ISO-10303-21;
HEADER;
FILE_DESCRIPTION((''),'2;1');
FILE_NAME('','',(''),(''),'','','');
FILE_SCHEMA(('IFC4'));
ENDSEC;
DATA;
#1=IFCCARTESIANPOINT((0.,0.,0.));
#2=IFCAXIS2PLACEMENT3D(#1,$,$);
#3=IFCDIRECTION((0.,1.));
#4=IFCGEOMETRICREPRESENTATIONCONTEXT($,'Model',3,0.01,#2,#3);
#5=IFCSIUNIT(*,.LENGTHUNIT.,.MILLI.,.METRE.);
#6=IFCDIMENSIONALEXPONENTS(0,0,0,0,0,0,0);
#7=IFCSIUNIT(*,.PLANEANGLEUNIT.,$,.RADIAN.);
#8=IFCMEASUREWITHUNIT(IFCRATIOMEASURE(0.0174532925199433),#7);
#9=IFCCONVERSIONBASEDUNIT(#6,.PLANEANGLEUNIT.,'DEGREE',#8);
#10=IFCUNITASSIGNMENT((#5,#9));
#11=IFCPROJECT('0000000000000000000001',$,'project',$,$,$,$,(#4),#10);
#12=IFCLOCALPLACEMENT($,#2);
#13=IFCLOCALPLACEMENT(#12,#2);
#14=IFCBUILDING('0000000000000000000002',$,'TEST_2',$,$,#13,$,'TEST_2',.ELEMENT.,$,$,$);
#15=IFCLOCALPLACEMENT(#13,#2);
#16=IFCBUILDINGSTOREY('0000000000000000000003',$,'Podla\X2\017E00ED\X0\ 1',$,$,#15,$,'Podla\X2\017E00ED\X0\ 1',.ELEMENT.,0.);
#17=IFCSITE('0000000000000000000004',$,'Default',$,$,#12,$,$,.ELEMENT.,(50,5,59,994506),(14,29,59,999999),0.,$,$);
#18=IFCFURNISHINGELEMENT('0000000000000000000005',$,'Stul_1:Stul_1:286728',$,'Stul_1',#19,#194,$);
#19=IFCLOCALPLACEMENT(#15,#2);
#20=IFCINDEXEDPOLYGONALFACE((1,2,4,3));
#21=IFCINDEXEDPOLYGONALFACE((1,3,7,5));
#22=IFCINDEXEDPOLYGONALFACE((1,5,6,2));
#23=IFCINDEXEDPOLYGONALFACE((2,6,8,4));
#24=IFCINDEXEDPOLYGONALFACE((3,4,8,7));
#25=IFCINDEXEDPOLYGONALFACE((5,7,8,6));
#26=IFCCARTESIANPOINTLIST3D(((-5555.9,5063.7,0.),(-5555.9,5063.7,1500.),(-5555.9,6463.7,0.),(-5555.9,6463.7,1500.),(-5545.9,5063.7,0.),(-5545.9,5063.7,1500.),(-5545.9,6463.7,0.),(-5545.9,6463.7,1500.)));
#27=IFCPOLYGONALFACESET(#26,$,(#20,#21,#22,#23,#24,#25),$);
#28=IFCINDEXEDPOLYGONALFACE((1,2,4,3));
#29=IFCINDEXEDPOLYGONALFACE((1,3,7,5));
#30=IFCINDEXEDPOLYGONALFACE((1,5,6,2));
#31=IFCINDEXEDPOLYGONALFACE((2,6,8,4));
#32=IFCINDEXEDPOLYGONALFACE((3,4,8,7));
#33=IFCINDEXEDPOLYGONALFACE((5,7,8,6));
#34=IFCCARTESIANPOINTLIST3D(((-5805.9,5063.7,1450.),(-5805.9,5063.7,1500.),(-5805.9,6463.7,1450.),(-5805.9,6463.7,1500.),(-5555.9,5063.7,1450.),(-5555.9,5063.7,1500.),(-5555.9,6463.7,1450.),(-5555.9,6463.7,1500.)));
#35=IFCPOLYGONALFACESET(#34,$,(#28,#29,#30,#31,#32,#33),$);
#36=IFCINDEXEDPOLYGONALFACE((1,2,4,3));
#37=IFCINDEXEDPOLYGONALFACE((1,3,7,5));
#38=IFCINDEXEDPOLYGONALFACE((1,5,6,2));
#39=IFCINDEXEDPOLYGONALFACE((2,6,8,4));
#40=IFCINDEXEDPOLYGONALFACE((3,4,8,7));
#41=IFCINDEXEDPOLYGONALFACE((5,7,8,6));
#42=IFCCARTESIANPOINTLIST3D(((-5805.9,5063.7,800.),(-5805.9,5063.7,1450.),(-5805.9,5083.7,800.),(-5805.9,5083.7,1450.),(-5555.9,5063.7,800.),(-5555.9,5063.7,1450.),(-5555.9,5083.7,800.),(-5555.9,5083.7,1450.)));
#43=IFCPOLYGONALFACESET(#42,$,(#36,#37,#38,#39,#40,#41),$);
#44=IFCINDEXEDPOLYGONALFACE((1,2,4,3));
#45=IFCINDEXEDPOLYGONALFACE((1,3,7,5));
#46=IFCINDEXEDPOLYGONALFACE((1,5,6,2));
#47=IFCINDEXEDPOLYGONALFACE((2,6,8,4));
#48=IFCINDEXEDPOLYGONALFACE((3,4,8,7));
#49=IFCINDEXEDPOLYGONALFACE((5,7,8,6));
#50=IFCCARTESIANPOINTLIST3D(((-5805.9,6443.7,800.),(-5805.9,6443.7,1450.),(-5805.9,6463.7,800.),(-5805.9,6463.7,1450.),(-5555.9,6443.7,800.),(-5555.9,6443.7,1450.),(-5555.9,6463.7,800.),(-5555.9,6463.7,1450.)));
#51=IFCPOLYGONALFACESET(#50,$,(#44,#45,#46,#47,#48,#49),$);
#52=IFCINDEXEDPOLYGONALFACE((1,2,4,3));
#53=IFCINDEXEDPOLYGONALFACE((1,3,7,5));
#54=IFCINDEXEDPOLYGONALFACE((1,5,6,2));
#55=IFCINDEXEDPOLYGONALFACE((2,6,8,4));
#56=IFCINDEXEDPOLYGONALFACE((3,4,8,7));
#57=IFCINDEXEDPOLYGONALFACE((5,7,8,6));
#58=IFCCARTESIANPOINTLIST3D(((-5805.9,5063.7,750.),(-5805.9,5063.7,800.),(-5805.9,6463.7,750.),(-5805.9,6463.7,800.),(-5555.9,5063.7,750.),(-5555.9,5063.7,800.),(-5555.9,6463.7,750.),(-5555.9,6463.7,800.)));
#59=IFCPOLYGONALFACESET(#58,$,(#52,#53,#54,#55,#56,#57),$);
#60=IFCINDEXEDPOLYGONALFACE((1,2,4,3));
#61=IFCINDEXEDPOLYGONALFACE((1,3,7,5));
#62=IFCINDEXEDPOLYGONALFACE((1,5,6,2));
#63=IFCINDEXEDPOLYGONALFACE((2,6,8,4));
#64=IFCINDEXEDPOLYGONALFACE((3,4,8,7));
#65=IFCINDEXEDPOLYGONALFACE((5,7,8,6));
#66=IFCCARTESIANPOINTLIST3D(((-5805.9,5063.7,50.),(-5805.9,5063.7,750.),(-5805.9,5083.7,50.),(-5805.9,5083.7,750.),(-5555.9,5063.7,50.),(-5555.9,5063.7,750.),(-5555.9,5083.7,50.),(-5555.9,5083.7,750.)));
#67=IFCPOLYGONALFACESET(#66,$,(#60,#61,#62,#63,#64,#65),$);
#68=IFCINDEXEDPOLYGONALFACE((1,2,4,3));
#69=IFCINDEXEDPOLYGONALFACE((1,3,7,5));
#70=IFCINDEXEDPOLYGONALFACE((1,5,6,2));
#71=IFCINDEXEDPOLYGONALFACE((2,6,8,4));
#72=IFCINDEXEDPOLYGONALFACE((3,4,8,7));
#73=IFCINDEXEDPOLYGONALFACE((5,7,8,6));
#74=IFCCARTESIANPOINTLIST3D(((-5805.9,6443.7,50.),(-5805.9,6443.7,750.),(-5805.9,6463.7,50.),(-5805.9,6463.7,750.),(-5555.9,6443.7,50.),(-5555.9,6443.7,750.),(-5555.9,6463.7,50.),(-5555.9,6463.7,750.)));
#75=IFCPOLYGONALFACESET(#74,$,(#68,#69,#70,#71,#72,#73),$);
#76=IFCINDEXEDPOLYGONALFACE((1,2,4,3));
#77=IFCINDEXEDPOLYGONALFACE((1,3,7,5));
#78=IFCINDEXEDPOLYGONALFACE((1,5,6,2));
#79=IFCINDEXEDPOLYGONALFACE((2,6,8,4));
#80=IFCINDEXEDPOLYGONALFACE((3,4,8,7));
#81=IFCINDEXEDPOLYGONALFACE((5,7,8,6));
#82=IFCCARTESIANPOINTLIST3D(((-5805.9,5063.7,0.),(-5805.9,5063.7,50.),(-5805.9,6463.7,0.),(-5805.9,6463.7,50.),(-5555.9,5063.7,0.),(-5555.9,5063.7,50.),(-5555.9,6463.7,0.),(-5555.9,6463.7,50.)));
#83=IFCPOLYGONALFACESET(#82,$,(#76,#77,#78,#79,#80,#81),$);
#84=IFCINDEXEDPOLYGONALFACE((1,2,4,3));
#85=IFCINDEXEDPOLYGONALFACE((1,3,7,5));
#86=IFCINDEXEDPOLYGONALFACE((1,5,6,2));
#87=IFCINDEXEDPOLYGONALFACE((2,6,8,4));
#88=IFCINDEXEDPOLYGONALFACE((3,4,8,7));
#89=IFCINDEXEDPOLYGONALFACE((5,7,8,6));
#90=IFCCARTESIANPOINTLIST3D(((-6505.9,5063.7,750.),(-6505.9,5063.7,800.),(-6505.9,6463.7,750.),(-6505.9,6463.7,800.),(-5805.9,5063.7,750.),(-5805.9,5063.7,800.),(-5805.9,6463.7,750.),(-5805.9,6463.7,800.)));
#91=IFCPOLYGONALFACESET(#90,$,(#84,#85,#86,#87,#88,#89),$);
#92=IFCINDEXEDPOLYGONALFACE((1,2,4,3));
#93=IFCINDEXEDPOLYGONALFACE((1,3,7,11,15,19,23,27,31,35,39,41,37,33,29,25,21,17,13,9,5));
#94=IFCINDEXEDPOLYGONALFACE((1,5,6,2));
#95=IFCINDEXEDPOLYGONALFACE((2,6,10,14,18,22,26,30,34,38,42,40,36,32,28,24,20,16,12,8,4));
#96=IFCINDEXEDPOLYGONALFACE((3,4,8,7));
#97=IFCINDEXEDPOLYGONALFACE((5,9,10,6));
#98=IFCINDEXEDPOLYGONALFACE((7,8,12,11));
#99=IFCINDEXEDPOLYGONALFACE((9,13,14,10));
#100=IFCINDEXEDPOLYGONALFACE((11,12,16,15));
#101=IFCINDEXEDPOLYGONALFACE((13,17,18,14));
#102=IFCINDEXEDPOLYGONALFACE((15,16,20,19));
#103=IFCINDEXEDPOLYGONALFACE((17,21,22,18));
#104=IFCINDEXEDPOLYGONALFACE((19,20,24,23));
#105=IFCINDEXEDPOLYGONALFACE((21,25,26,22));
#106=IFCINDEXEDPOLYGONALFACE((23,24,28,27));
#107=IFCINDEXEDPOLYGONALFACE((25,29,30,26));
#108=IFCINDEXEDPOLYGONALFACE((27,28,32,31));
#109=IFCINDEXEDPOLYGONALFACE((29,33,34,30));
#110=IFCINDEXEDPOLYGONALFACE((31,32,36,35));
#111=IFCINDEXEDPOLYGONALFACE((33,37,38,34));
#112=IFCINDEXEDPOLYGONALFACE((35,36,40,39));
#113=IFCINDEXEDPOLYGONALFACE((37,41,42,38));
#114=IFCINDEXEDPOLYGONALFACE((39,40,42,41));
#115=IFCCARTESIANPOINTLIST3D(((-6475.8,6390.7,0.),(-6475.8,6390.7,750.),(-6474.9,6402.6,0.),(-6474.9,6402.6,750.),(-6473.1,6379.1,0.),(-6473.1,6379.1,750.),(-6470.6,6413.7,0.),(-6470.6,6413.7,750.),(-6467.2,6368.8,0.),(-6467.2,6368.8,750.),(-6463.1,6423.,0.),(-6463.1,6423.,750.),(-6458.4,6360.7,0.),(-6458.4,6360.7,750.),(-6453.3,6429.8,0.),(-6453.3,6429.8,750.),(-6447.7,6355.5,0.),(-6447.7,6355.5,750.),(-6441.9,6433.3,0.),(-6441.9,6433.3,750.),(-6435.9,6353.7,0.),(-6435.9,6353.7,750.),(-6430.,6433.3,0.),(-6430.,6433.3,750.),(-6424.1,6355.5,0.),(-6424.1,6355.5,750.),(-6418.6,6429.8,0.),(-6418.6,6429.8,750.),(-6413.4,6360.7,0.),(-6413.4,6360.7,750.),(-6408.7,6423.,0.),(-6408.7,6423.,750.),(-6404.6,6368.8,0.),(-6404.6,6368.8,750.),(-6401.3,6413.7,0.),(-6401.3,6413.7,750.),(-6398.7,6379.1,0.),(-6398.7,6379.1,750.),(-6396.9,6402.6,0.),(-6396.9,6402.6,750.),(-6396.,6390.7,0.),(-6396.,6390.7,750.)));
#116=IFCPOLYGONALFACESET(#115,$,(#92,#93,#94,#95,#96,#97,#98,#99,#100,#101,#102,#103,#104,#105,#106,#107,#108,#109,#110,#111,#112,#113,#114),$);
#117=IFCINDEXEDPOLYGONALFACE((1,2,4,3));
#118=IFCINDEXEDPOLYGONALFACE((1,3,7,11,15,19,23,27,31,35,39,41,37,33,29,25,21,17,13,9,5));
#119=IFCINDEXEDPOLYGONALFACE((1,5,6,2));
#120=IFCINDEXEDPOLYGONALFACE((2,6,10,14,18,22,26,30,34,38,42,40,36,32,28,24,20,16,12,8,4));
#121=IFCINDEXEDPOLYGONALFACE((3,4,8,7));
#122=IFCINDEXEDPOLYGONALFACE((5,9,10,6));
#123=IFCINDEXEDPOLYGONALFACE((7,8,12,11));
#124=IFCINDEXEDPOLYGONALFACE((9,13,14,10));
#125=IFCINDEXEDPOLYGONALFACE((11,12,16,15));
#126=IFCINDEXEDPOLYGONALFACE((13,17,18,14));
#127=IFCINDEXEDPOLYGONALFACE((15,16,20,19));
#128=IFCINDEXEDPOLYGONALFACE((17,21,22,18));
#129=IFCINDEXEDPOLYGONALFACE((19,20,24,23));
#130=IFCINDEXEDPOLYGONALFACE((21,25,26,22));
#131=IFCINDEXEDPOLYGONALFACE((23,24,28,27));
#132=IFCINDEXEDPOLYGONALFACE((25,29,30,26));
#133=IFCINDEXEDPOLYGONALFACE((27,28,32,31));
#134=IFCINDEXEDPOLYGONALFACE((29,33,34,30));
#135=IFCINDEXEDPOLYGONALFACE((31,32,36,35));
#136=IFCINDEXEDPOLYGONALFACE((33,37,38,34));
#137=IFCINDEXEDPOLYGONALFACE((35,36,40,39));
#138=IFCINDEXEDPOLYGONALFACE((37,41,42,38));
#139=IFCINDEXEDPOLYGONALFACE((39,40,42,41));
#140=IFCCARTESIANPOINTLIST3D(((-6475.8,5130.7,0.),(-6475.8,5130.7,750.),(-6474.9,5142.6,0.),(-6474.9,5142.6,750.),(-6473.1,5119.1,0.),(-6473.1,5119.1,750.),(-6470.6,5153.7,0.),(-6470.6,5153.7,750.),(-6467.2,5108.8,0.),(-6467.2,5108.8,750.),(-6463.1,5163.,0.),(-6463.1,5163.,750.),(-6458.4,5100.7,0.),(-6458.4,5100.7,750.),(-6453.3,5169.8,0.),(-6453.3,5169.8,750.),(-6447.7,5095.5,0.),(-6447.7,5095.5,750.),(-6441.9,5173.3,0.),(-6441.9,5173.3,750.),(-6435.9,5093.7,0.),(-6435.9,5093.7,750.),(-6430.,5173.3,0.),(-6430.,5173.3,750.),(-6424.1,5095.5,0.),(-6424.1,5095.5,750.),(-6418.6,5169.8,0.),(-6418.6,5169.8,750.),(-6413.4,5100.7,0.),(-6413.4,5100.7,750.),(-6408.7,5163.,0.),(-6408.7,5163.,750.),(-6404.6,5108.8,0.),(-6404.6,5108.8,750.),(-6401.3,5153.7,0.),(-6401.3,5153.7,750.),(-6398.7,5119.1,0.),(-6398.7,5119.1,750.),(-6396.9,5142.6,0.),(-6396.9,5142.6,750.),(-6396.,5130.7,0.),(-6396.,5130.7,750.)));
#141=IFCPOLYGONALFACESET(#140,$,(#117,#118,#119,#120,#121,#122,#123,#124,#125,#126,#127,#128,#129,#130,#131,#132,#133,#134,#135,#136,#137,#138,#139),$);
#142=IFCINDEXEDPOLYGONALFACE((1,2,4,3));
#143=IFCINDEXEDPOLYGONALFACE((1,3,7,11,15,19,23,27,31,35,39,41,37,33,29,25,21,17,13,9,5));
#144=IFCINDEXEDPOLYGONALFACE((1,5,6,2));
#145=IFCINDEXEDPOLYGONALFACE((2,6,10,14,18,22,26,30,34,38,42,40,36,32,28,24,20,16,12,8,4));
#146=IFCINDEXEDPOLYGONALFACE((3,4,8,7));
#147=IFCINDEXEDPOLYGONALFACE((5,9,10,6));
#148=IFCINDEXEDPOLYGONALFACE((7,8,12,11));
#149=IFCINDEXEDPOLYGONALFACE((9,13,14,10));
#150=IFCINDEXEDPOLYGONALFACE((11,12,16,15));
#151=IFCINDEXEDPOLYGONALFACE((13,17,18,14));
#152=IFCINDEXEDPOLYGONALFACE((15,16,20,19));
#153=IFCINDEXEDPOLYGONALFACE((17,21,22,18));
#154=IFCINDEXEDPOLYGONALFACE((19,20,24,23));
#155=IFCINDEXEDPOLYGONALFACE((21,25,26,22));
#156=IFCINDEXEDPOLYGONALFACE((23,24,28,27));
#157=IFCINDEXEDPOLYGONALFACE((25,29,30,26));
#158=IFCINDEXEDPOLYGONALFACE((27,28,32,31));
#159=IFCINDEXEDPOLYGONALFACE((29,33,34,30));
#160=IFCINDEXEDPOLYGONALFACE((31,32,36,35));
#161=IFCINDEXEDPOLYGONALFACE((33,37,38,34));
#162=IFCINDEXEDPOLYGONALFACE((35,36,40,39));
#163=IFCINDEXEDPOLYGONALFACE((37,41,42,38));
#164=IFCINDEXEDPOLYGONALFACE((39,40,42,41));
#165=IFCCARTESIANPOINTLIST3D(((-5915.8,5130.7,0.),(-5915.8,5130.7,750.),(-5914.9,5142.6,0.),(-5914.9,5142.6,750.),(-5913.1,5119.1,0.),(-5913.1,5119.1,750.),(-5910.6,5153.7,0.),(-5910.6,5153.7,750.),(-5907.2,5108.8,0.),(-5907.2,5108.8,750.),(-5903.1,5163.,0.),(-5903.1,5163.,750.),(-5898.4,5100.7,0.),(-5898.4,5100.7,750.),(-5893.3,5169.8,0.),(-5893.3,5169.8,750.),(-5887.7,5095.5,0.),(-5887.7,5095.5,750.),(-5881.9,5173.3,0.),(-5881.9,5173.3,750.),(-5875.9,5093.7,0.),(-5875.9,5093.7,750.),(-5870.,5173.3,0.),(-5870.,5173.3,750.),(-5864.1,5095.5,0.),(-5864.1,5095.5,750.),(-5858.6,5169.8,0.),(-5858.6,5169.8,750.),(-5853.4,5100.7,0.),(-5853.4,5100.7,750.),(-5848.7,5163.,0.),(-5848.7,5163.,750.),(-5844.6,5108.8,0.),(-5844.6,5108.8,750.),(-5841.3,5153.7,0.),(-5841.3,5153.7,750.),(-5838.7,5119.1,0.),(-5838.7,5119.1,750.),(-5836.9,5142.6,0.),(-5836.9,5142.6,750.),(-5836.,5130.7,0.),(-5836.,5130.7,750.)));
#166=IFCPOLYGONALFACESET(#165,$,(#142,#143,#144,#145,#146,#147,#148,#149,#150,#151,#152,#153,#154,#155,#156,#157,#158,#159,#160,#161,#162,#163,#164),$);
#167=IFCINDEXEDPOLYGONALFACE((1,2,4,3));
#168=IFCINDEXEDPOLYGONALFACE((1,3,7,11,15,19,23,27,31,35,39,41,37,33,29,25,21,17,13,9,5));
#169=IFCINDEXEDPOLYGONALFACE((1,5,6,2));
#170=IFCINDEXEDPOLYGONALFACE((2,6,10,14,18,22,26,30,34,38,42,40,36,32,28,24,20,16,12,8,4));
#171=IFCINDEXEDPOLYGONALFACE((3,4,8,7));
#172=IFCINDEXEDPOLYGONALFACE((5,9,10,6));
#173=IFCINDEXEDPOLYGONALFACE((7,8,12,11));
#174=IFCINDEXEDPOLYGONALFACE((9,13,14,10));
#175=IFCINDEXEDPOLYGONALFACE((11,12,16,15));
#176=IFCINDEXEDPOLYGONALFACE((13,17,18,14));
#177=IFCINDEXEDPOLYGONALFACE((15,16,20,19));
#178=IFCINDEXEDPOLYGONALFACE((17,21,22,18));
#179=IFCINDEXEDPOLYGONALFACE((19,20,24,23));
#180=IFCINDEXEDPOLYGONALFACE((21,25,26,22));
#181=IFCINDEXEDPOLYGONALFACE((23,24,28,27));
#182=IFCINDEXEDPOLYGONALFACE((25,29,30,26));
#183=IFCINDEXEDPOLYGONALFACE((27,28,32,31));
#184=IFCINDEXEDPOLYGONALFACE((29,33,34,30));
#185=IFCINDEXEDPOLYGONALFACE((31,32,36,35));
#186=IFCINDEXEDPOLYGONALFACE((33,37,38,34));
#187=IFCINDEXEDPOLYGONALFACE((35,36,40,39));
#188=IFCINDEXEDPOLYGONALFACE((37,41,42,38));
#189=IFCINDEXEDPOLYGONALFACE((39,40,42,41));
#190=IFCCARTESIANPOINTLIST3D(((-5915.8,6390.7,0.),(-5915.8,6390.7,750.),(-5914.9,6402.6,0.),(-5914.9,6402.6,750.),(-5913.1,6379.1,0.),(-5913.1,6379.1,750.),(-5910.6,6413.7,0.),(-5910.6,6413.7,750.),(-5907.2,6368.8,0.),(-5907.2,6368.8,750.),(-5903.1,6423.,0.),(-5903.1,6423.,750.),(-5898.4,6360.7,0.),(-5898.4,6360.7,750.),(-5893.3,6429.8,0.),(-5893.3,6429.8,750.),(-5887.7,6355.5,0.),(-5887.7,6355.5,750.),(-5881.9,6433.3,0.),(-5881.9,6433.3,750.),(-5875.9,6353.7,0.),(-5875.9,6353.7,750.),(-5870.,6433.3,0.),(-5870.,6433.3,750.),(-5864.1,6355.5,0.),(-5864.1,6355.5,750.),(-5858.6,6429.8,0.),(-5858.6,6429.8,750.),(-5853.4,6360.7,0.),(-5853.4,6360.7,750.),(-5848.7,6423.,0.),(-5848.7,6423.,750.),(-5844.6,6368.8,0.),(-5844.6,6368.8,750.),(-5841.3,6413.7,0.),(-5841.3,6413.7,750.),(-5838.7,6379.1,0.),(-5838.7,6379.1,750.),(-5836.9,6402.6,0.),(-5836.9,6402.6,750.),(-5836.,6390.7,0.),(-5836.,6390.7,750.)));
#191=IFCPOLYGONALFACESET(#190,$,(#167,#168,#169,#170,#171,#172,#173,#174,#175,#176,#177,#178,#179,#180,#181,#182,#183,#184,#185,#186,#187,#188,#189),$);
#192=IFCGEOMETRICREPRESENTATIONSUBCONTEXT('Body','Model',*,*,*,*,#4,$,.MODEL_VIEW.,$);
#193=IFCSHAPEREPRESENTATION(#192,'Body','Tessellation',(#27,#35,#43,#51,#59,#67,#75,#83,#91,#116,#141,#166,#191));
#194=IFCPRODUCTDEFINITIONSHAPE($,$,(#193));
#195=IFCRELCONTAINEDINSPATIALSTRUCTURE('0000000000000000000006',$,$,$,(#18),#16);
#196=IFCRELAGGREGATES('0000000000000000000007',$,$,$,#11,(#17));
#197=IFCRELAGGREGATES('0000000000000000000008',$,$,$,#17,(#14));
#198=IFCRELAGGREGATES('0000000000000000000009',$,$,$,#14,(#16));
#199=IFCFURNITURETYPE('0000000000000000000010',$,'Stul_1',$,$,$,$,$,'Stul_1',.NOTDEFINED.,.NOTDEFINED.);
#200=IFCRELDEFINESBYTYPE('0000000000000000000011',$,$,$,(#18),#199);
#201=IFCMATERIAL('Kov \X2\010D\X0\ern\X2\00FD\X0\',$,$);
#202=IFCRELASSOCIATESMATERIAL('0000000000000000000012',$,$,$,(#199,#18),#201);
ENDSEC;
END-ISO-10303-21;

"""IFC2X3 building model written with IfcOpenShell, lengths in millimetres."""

from ifc_helpers import new_model, entity, si_unit, converted_unit, direction, frame, frame_2d, origin, origin_2d_with_axis, place, context, subcontext, project, spatial, rectangle, circle, extrude, source, transform, mapped, material, type_object, type_shapes, element, save


model = new_model("IFC2X3")

# Units and contexts
model_context = context("Model", 3, precision=0.01, world=origin(), true_north=direction((0.0, 1.0)))
body_context = subcontext(model_context, "Body", "Model", "MODEL_VIEW")
ifc_project = project(units=[si_unit("LENGTHUNIT", "METRE", prefix="MILLI"), converted_unit("PLANEANGLEUNIT", "DEGREE", entity("IfcRatioMeasure", 0.0174532925199433), si_unit("PLANEANGLEUNIT", "RADIAN"), dimensions=[0, 0, 0, 0, 0, 0, 0])], contexts=[model_context])

# Site, building, storey
site_placement = place(None, origin())
site = spatial("IfcSite", under=ifc_project, at=site_placement, Name="Default", CompositionType="ELEMENT", RefLatitude=(50, 5, 59, 994506), RefLongitude=(14, 29, 59, 999999), RefElevation=0.0)
building_placement = place(site_placement, origin())
building = spatial("IfcBuilding", under=site, at=building_placement, Name="TEST_2", LongName="TEST_2", CompositionType="ELEMENT")
storey_placement = place(building_placement, origin())
storey = spatial("IfcBuildingStorey", under=building, at=storey_placement, Name="Podlaží 1", LongName="Podlaží 1", CompositionType="ELEMENT", Elevation=0.0)

# Furnishing element
ifc_material_1 = material(Name="Kov černý")
furniture_type = type_object("IfcFurnitureType", Name="Stul_1", ElementType="Stul_1", material=ifc_material_1)
shared_shape_1 = source(origin(), body_context, "Body", "SweptSolid", [
    extrude(rectangle(XDim=1400.0, YDim=10.0, at=origin_2d_with_axis()), frame((0.0, 605.0, 0.0), z_axis=(0.0, 0.0, 1.0), x_axis=(-1.0, 0.0, 0.0)), (0.0, 0.0, 1.0), 1500.0),
    extrude(rectangle(XDim=1400.0, YDim=250.0, at=frame_2d((0.0, 0.0), x_axis=(1.0, 0.0))), frame((0.0, 475.0, 1450.0), z_axis=(0.0, 0.0, 1.0), x_axis=(-1.0, 0.0, 0.0)), (0.0, 0.0, 1.0), 50.0),
    extrude(rectangle(XDim=20.0, YDim=250.0, at=origin_2d_with_axis()), frame((690.0, 475.0, 800.0), z_axis=(0.0, 0.0, 1.0), x_axis=(-1.0, 0.0, 0.0)), (0.0, 0.0, 1.0), 650.0),
    extrude(rectangle(XDim=20.0, YDim=250.0, at=frame_2d((0.0, 0.0), x_axis=(1.0, 0.0))), frame((-690.0, 475.0, 800.0), z_axis=(0.0, 0.0, 1.0), x_axis=(-1.0, 0.0, 0.0)), (0.0, 0.0, 1.0), 650.0),
    extrude(rectangle(XDim=1400.0, YDim=250.0, at=origin_2d_with_axis()), frame((0.0, 475.0, 750.0), z_axis=(0.0, 0.0, 1.0), x_axis=(-1.0, 0.0, 0.0)), (0.0, 0.0, 1.0), 50.0),
    extrude(rectangle(XDim=20.0, YDim=250.0, at=origin_2d_with_axis()), frame((690.0, 475.0, 50.0), z_axis=(0.0, 0.0, 1.0), x_axis=(-1.0, 0.0, 0.0)), (0.0, 0.0, 1.0), 700.0),
    extrude(rectangle(XDim=20.0, YDim=250.0, at=frame_2d((0.0, 0.0), x_axis=(1.0, 0.0))), frame((-690.0, 475.0, 50.0), z_axis=(0.0, 0.0, 1.0), x_axis=(-1.0, 0.0, 0.0)), (0.0, 0.0, 1.0), 700.0),
    extrude(rectangle(XDim=1400.0, YDim=250.0, at=origin_2d_with_axis()), frame((0.0, 475.0, 0.0), z_axis=(0.0, 0.0, 1.0), x_axis=(-1.0, 0.0, 0.0)), (0.0, 0.0, 1.0), 50.0),
    extrude(rectangle(XDim=1400.0, YDim=700.0, at=origin_2d_with_axis()), frame((0.0, 0.0, 750.0), z_axis=(0.0, 0.0, 1.0), x_axis=(-1.0, 0.0, 0.0)), (0.0, 0.0, 1.0), 50.0),
    extrude(circle(Radius=40.0, at=frame_2d((0.0, 0.0), x_axis=(1.0, 0.0))), frame((-630.0, -280.0, 0.0)), (0.0, 0.0, 1.0), 750.0),
    extrude(circle(Radius=40.0, at=frame_2d((0.0, 0.0), x_axis=(1.0, 0.0))), frame((630.0, -280.0, 0.0)), (0.0, 0.0, 1.0), 750.0),
    extrude(circle(Radius=40.0, at=frame_2d((0.0, 0.0), x_axis=(1.0, 0.0))), frame((630.0, 280.0, 0.0)), (0.0, 0.0, 1.0), 750.0),
    extrude(circle(Radius=40.0, at=frame_2d((0.0, 0.0), x_axis=(1.0, 0.0))), frame((-630.0, 280.0, 0.0)), (0.0, 0.0, 1.0), 750.0),
])
type_shapes(furniture_type, [shared_shape_1])
for number, where, z_axis, x_axis, name in (
    (1, (-6155.9, 5763.7, 0.0), (0.0, 0.0, 1.0), (0.0, -1.0, 0.0), "Stul_1:Stul_1:286728"),
):
    element("IfcFurnishingElement", number, at=place(storey_placement, frame(where, z_axis=z_axis, x_axis=x_axis)), inside=storey, type_object=furniture_type, material=ifc_material_1, Name=name, ObjectType="Stul_1", context=body_context, shape_type="MappedRepresentation", body=[
        mapped(shared_shape_1, transform((0.0, 0.0, 0.0), scale=1.0)),
    ])

save(model, "model.ifc")
